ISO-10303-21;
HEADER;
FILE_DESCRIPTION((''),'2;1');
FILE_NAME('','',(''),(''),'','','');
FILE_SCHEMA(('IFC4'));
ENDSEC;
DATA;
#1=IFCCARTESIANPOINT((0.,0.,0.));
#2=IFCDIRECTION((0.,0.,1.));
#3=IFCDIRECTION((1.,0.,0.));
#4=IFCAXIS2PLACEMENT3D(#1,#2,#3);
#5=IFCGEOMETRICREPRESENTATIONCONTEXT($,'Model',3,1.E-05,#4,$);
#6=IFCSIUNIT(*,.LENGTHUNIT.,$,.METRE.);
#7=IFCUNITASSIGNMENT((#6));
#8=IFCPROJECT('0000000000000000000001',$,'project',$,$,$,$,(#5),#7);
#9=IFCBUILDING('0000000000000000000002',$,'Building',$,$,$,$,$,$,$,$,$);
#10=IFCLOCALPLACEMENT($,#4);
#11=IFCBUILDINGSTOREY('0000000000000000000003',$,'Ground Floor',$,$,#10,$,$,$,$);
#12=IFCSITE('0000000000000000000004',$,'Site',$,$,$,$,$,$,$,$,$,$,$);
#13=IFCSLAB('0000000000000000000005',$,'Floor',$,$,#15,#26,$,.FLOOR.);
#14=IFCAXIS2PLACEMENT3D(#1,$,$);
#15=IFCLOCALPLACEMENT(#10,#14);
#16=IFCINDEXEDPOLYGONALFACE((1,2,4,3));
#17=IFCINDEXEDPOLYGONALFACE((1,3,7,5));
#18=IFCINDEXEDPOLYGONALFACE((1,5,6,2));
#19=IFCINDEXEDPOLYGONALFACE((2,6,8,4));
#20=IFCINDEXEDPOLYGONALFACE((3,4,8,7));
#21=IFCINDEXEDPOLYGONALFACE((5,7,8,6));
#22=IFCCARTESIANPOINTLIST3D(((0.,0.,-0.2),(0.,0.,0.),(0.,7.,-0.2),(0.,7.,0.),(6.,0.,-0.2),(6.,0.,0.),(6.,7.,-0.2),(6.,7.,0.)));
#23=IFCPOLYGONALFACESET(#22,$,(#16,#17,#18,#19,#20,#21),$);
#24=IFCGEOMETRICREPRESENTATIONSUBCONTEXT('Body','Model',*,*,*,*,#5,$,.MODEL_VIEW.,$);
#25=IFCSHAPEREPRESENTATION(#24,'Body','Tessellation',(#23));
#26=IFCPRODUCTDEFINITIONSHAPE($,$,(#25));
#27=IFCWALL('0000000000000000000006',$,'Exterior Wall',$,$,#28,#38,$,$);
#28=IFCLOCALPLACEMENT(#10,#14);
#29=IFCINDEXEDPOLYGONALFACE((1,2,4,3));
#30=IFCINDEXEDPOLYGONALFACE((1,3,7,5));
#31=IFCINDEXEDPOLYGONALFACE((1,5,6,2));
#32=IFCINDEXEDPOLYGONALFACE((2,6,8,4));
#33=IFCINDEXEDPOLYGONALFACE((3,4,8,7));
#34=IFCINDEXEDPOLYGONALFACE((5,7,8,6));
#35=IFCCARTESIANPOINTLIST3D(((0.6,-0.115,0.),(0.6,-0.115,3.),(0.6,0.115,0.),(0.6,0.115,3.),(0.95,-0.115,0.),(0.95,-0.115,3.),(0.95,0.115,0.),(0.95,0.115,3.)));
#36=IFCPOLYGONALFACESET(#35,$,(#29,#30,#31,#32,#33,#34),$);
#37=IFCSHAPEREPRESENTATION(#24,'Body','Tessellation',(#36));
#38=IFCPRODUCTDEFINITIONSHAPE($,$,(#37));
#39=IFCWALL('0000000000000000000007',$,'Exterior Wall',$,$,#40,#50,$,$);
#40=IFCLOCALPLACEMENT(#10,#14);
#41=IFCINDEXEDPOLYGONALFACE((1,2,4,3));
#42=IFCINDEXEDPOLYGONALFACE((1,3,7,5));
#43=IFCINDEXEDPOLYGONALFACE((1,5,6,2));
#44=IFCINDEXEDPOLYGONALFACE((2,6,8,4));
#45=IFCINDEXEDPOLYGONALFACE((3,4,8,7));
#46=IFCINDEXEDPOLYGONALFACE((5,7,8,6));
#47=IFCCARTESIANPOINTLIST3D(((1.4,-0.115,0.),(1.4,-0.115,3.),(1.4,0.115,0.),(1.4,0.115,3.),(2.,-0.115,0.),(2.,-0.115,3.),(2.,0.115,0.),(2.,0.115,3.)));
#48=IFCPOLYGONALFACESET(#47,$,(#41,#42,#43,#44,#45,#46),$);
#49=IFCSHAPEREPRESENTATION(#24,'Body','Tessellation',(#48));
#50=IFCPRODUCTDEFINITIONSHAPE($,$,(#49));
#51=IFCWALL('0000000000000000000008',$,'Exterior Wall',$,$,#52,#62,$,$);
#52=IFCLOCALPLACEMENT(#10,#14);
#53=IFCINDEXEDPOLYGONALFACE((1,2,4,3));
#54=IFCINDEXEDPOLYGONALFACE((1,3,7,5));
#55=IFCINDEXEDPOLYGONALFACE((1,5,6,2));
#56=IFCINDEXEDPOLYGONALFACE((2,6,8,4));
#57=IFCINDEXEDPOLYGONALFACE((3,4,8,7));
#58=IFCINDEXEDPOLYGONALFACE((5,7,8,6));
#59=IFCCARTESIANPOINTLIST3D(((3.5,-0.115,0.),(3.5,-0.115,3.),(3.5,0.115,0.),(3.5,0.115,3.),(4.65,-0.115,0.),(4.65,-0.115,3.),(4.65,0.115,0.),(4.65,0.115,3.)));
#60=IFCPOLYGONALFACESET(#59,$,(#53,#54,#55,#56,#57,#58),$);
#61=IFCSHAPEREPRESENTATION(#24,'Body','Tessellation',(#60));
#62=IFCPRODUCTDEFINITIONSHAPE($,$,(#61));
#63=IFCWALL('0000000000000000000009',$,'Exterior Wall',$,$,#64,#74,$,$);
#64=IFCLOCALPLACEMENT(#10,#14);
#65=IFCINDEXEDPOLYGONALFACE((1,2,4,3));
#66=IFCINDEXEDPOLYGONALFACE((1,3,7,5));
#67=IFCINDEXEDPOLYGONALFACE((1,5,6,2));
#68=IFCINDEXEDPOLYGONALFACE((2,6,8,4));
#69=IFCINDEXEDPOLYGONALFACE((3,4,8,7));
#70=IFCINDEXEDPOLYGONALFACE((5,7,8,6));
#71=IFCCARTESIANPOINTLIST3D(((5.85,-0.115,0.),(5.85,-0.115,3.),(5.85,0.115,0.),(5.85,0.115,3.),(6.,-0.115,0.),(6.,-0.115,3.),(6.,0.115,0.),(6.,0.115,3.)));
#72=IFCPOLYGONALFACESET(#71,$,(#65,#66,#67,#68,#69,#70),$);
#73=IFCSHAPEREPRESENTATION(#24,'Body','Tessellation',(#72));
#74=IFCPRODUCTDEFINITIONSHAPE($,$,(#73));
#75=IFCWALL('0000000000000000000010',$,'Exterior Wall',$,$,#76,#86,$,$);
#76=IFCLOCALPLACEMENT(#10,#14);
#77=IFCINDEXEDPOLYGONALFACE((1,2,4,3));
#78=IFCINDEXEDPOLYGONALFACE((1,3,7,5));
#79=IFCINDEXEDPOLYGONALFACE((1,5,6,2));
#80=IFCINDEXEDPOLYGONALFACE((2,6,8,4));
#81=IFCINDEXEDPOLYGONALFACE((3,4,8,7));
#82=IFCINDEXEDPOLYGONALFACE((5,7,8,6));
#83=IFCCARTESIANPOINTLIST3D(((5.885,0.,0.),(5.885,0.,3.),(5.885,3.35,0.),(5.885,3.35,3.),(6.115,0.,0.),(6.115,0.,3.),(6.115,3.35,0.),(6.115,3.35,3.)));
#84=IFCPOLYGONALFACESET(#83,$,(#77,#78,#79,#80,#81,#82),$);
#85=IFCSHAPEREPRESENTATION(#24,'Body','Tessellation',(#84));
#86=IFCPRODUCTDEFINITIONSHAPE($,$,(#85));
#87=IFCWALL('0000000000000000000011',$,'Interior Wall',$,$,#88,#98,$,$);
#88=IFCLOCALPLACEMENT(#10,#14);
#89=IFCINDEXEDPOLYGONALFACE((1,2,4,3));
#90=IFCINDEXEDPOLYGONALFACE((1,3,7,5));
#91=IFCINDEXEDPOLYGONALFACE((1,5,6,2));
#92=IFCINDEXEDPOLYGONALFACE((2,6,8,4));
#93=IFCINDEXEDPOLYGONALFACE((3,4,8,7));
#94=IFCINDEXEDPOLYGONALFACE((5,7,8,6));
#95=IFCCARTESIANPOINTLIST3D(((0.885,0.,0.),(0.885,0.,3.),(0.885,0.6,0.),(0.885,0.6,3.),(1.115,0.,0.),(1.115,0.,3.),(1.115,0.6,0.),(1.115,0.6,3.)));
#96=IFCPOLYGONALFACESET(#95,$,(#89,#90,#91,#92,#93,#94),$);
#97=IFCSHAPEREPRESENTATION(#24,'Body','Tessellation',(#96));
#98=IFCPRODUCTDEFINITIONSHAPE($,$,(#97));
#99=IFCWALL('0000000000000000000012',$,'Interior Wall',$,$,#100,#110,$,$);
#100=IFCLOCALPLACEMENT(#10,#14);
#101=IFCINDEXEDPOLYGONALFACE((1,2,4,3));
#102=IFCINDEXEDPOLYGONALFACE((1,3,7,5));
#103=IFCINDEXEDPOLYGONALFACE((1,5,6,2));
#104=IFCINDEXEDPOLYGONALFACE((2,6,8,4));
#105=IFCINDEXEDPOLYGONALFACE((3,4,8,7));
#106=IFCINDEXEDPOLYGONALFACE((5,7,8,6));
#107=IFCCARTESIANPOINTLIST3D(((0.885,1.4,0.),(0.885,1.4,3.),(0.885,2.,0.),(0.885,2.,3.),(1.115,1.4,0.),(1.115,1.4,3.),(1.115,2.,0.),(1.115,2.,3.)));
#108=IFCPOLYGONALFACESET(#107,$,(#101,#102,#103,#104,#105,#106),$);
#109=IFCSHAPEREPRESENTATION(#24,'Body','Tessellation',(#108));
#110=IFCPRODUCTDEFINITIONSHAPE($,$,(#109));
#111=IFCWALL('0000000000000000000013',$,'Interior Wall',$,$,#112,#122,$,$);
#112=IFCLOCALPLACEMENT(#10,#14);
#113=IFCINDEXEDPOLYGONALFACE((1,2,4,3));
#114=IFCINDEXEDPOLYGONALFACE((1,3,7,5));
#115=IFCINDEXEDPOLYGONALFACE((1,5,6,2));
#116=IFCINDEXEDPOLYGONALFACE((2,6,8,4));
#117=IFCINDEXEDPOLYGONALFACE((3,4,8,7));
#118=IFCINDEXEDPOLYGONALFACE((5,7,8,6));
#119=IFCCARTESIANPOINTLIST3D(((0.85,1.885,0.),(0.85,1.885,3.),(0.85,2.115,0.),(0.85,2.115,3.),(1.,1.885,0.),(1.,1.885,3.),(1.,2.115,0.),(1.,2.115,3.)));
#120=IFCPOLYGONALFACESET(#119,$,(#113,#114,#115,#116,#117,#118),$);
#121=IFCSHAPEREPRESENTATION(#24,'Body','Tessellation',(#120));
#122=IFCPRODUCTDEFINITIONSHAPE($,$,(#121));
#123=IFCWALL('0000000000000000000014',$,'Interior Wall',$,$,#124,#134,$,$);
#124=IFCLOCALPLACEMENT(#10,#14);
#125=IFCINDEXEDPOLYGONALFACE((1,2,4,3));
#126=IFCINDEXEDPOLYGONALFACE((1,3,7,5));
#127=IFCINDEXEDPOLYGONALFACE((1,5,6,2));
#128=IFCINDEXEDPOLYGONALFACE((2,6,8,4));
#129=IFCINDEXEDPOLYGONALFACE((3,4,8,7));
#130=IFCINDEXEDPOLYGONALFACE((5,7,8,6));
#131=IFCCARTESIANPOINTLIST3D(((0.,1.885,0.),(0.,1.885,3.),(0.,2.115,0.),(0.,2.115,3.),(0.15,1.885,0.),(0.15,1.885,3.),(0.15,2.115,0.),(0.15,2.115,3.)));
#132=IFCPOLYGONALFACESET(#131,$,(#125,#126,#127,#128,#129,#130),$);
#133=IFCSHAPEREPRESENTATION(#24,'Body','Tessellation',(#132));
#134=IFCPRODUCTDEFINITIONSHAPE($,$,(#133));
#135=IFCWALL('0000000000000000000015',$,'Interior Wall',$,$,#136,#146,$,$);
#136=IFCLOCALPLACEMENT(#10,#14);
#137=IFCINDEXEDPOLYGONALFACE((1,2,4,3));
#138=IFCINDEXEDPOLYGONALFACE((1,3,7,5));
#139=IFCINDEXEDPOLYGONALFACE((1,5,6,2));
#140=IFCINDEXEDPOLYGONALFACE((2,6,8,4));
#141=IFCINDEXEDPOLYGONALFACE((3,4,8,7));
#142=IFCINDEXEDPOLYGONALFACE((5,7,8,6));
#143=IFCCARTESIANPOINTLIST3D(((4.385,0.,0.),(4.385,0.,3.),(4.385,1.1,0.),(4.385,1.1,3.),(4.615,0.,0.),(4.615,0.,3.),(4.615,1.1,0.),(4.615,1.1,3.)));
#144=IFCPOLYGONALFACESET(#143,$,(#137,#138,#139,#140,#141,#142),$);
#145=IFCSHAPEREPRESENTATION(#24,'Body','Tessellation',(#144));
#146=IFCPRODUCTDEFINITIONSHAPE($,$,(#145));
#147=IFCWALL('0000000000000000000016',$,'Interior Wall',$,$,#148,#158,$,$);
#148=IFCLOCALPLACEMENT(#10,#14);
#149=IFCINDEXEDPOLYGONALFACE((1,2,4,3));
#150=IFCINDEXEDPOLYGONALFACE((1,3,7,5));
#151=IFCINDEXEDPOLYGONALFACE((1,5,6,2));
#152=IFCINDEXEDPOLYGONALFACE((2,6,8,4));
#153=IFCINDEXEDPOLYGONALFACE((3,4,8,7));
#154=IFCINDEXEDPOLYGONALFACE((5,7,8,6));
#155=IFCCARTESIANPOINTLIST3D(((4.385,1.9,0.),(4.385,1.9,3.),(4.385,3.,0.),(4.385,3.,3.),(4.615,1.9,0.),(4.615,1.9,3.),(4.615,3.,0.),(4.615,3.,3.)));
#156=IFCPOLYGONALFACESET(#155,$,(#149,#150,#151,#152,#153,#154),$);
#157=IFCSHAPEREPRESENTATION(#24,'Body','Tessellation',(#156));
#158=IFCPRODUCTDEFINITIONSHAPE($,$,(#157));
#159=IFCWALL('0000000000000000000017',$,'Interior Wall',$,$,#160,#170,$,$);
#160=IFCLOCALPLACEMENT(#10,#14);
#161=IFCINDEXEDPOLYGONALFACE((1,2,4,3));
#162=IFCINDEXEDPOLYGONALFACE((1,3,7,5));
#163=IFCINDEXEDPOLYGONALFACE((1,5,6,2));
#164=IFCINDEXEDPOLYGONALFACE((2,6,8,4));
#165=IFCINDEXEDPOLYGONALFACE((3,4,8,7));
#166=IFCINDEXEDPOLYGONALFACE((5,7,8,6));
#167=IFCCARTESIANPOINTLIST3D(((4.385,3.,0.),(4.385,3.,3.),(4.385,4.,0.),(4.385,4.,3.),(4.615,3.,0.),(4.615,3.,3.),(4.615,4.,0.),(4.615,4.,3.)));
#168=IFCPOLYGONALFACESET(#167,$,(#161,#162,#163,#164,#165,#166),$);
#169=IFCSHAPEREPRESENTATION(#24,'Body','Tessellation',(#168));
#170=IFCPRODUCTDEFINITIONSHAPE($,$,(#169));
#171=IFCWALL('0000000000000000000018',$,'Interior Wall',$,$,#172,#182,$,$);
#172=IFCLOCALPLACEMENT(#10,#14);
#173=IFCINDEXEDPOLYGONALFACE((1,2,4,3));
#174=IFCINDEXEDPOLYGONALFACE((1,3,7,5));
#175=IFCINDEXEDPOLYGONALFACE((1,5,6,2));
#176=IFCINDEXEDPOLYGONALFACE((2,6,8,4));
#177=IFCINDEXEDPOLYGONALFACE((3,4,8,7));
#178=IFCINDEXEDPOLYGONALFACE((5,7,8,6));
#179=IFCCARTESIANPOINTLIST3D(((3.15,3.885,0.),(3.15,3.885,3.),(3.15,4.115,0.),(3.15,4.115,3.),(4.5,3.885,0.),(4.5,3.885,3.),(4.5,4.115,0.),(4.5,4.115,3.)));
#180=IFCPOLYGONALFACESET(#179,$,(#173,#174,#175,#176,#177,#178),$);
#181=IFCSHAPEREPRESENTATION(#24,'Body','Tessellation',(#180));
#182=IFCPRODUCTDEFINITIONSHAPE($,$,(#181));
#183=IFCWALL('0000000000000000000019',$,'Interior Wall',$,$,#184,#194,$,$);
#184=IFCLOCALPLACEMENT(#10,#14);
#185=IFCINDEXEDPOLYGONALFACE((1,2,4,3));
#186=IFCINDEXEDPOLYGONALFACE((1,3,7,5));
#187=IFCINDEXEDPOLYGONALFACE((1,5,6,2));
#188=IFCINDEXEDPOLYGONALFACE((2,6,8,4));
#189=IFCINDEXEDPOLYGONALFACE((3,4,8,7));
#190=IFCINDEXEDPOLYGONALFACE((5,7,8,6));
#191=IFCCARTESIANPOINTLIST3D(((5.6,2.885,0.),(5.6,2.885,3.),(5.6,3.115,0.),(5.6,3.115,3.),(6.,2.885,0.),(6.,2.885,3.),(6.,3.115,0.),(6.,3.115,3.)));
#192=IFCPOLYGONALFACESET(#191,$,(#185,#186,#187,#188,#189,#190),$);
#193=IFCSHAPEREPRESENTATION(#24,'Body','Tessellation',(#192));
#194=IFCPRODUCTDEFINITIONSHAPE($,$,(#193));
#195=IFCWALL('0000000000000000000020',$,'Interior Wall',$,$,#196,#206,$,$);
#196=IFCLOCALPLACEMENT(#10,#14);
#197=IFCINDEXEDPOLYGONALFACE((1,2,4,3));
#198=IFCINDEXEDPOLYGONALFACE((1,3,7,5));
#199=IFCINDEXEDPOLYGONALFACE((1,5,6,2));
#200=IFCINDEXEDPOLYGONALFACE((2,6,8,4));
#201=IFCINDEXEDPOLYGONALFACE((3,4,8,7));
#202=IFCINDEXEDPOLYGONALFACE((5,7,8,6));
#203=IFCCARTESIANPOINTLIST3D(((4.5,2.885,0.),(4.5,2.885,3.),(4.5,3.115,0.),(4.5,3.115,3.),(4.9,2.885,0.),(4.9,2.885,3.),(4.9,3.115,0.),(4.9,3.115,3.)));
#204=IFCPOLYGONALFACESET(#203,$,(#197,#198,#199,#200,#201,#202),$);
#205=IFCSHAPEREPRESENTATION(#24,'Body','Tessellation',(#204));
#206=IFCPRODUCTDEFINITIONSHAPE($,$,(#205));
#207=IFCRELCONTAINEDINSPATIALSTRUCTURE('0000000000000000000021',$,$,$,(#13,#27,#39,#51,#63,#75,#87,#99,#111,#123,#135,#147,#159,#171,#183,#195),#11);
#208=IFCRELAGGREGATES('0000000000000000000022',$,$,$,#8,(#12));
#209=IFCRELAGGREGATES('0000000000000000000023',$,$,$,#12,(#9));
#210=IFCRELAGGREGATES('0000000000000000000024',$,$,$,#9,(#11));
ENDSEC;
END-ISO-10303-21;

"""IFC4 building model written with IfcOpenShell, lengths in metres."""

from ifc_helpers import new_model, si_unit, frame, origin_with_axes, place, context, subcontext, project, spatial, indexed_curve, outline, extrude, element, save


model = new_model("IFC4")

# Units and contexts
model_context = context("Model", 3, precision=1e-05, world=origin_with_axes())
body_context = subcontext(model_context, "Body", "Model", "MODEL_VIEW")
ifc_project = project(units=[si_unit("LENGTHUNIT", "METRE")], contexts=[model_context])

# Site, building, storey
site = spatial("IfcSite", under=ifc_project, Name="Site")
building = spatial("IfcBuilding", under=site, Name="Building")
storey_placement = place(None, origin_with_axes())
storey = spatial("IfcBuildingStorey", under=building, at=storey_placement, Name="Ground Floor")

# Slab
slab_placement = place(storey_placement, frame((0.0, 0.0, -0.2), z_axis=(0.0, 0.0, 1.0), x_axis=(1.0, 0.0, 0.0)))
element("IfcSlab", 1, at=slab_placement, inside=storey, Name="Floor", PredefinedType="FLOOR", context=body_context, shape_type="SweptSolid", body=[
    extrude(outline(indexed_curve([(0.0, 0.0), (6.0, 0.0), (6.0, 7.0), (0.0, 7.0)])), None, (0.0, 0.0, 1.0), 0.2),
])

# Walls
wall_1_placement = place(storey_placement, frame((0.95, 0.0, 0.0), z_axis=(0.0, 0.0, 1.0), x_axis=(-1.0, 0.0, 0.0)))
element("IfcWall", 2, at=wall_1_placement, inside=storey, Name="Exterior Wall", context=body_context, shape_type="SweptSolid", body=[
    extrude(outline(indexed_curve([(0.0, 0.0), (0.0, 0.23), (0.35, 0.23), (0.35, 0.0), (0.0, 0.0)], self_intersect=False)), frame((0.0, -0.115, 0.0), z_axis=(0.0, 0.0, 1.0), x_axis=(1.0, 0.0, 0.0)), (0.0, 0.0, 1.0), 3.0),
])
wall_2_placement = place(storey_placement, frame((1.4, 0.0, 0.0), z_axis=(0.0, 0.0, 1.0), x_axis=(1.0, 0.0, 0.0)))
element("IfcWall", 3, at=wall_2_placement, inside=storey, Name="Exterior Wall", context=body_context, shape_type="SweptSolid", body=[
    extrude(outline(indexed_curve([(0.0, 0.0), (0.0, 0.23), (0.6, 0.23), (0.6, 0.0), (0.0, 0.0)], self_intersect=False)), frame((0.0, -0.115, 0.0), z_axis=(0.0, 0.0, 1.0), x_axis=(1.0, 0.0, 0.0)), (0.0, 0.0, 1.0), 3.0),
])
wall_3_placement = place(storey_placement, frame((3.5, 0.0, 0.0), z_axis=(0.0, 0.0, 1.0), x_axis=(1.0, 0.0, 0.0)))
element("IfcWall", 4, at=wall_3_placement, inside=storey, Name="Exterior Wall", context=body_context, shape_type="SweptSolid", body=[
    extrude(outline(indexed_curve([(0.0, 0.0), (0.0, 0.23), (1.15, 0.23), (1.15, 0.0), (0.0, 0.0)], self_intersect=False)), frame((0.0, -0.115, 0.0), z_axis=(0.0, 0.0, 1.0), x_axis=(1.0, 0.0, 0.0)), (0.0, 0.0, 1.0), 3.0),
])
wall_4_placement = place(storey_placement, frame((5.85, 0.0, 0.0), z_axis=(0.0, 0.0, 1.0), x_axis=(1.0, 0.0, 0.0)))
element("IfcWall", 5, at=wall_4_placement, inside=storey, Name="Exterior Wall", context=body_context, shape_type="SweptSolid", body=[
    extrude(outline(indexed_curve([(0.0, 0.0), (0.0, 0.23), (0.15, 0.23), (0.15, 0.0), (0.0, 0.0)], self_intersect=False)), frame((0.0, -0.115, 0.0), z_axis=(0.0, 0.0, 1.0), x_axis=(1.0, 0.0, 0.0)), (0.0, 0.0, 1.0), 3.0),
])
wall_5_placement = place(storey_placement, frame((6.0, 0.0, 0.0), z_axis=(0.0, 0.0, 1.0), x_axis=(0.0, 1.0, 0.0)))
element("IfcWall", 6, at=wall_5_placement, inside=storey, Name="Exterior Wall", context=body_context, shape_type="SweptSolid", body=[
    extrude(outline(indexed_curve([(0.0, 0.0), (0.0, 0.23), (3.35, 0.23), (3.35, 0.0), (0.0, 0.0)], self_intersect=False)), frame((0.0, -0.115, 0.0), z_axis=(0.0, 0.0, 1.0), x_axis=(1.0, 0.0, 0.0)), (0.0, 0.0, 1.0), 3.0),
])
wall_6_placement = place(storey_placement, frame((1.0, 0.0, 0.0), z_axis=(0.0, 0.0, 1.0), x_axis=(0.0, 1.0, 0.0)))
element("IfcWall", 7, at=wall_6_placement, inside=storey, Name="Interior Wall", context=body_context, shape_type="SweptSolid", body=[
    extrude(outline(indexed_curve([(0.0, 0.0), (0.0, 0.23), (0.6, 0.23), (0.6, 0.0), (0.0, 0.0)], self_intersect=False)), frame((0.0, -0.115, 0.0), z_axis=(0.0, 0.0, 1.0), x_axis=(1.0, 0.0, 0.0)), (0.0, 0.0, 1.0), 3.0),
])
wall_7_placement = place(storey_placement, frame((1.0, 1.4, 0.0), z_axis=(0.0, 0.0, 1.0), x_axis=(0.0, 1.0, 0.0)))
element("IfcWall", 8, at=wall_7_placement, inside=storey, Name="Interior Wall", context=body_context, shape_type="SweptSolid", body=[
    extrude(outline(indexed_curve([(0.0, 0.0), (0.0, 0.23), (0.6, 0.23), (0.6, 0.0), (0.0, 0.0)], self_intersect=False)), frame((0.0, -0.115, 0.0), z_axis=(0.0, 0.0, 1.0), x_axis=(1.0, 0.0, 0.0)), (0.0, 0.0, 1.0), 3.0),
])
for number, where, z_axis, x_axis, name in (
    (9, (1.0, 2.0, 0.0), (0.0, 0.0, 1.0), (-1.0, 0.0, 0.0), "Interior Wall"),
    (10, (0.15, 2.0, 0.0), (0.0, 0.0, 1.0), (-1.0, 0.0, 0.0), "Interior Wall"),
):
    element("IfcWall", number, at=place(storey_placement, frame(where, z_axis=z_axis, x_axis=x_axis)), inside=storey, Name=name, context=body_context, shape_type="SweptSolid", body=[
        extrude(outline(indexed_curve([(0.0, 0.0), (0.0, 0.23), (0.15, 0.23), (0.15, 0.0), (0.0, 0.0)], self_intersect=False)), frame((0.0, -0.115, 0.0), z_axis=(0.0, 0.0, 1.0), x_axis=(1.0, 0.0, 0.0)), (0.0, 0.0, 1.0), 3.0),
    ])
for number, where, z_axis, x_axis, name in (
    (11, (4.5, 0.0, 0.0), (0.0, 0.0, 1.0), (0.0, 1.0, 0.0), "Interior Wall"),
    (12, (4.5, 1.9, 0.0), (0.0, 0.0, 1.0), (0.0, 1.0, 0.0), "Interior Wall"),
):
    element("IfcWall", number, at=place(storey_placement, frame(where, z_axis=z_axis, x_axis=x_axis)), inside=storey, Name=name, context=body_context, shape_type="SweptSolid", body=[
        extrude(outline(indexed_curve([(0.0, 0.0), (0.0, 0.23), (1.1, 0.23), (1.1, 0.0), (0.0, 0.0)], self_intersect=False)), frame((0.0, -0.115, 0.0), z_axis=(0.0, 0.0, 1.0), x_axis=(1.0, 0.0, 0.0)), (0.0, 0.0, 1.0), 3.0),
    ])
wall_8_placement = place(storey_placement, frame((4.5, 3.0, 0.0), z_axis=(0.0, 0.0, 1.0), x_axis=(0.0, 1.0, 0.0)))
element("IfcWall", 13, at=wall_8_placement, inside=storey, Name="Interior Wall", context=body_context, shape_type="SweptSolid", body=[
    extrude(outline(indexed_curve([(0.0, 0.0), (0.0, 0.23), (1.0, 0.23), (1.0, 0.0), (0.0, 0.0)], self_intersect=False)), frame((0.0, -0.115, 0.0), z_axis=(0.0, 0.0, 1.0), x_axis=(1.0, 0.0, 0.0)), (0.0, 0.0, 1.0), 3.0),
])
wall_9_placement = place(storey_placement, frame((4.5, 4.0, 0.0), z_axis=(0.0, 0.0, 1.0), x_axis=(-1.0, 0.0, 0.0)))
element("IfcWall", 14, at=wall_9_placement, inside=storey, Name="Interior Wall", context=body_context, shape_type="SweptSolid", body=[
    extrude(outline(indexed_curve([(0.0, 0.0), (0.0, 0.23), (1.35, 0.23), (1.35, 0.0), (0.0, 0.0)], self_intersect=False)), frame((0.0, -0.115, 0.0), z_axis=(0.0, 0.0, 1.0), x_axis=(1.0, 0.0, 0.0)), (0.0, 0.0, 1.0), 3.0),
])
for number, where, z_axis, x_axis, name in (
    (15, (6.0, 3.0, 0.0), (0.0, 0.0, 1.0), (-1.0, 0.0, 0.0), "Interior Wall"),
    (16, (4.9, 3.0, 0.0), (0.0, 0.0, 1.0), (-1.0, 0.0, 0.0), "Interior Wall"),
):
    element("IfcWall", number, at=place(storey_placement, frame(where, z_axis=z_axis, x_axis=x_axis)), inside=storey, Name=name, context=body_context, shape_type="SweptSolid", body=[
        extrude(outline(indexed_curve([(0.0, 0.0), (0.0, 0.23), (0.4, 0.23), (0.4, 0.0), (0.0, 0.0)], self_intersect=False)), frame((0.0, -0.115, 0.0), z_axis=(0.0, 0.0, 1.0), x_axis=(1.0, 0.0, 0.0)), (0.0, 0.0, 1.0), 3.0),
    ])

save(model, "model.ifc")
